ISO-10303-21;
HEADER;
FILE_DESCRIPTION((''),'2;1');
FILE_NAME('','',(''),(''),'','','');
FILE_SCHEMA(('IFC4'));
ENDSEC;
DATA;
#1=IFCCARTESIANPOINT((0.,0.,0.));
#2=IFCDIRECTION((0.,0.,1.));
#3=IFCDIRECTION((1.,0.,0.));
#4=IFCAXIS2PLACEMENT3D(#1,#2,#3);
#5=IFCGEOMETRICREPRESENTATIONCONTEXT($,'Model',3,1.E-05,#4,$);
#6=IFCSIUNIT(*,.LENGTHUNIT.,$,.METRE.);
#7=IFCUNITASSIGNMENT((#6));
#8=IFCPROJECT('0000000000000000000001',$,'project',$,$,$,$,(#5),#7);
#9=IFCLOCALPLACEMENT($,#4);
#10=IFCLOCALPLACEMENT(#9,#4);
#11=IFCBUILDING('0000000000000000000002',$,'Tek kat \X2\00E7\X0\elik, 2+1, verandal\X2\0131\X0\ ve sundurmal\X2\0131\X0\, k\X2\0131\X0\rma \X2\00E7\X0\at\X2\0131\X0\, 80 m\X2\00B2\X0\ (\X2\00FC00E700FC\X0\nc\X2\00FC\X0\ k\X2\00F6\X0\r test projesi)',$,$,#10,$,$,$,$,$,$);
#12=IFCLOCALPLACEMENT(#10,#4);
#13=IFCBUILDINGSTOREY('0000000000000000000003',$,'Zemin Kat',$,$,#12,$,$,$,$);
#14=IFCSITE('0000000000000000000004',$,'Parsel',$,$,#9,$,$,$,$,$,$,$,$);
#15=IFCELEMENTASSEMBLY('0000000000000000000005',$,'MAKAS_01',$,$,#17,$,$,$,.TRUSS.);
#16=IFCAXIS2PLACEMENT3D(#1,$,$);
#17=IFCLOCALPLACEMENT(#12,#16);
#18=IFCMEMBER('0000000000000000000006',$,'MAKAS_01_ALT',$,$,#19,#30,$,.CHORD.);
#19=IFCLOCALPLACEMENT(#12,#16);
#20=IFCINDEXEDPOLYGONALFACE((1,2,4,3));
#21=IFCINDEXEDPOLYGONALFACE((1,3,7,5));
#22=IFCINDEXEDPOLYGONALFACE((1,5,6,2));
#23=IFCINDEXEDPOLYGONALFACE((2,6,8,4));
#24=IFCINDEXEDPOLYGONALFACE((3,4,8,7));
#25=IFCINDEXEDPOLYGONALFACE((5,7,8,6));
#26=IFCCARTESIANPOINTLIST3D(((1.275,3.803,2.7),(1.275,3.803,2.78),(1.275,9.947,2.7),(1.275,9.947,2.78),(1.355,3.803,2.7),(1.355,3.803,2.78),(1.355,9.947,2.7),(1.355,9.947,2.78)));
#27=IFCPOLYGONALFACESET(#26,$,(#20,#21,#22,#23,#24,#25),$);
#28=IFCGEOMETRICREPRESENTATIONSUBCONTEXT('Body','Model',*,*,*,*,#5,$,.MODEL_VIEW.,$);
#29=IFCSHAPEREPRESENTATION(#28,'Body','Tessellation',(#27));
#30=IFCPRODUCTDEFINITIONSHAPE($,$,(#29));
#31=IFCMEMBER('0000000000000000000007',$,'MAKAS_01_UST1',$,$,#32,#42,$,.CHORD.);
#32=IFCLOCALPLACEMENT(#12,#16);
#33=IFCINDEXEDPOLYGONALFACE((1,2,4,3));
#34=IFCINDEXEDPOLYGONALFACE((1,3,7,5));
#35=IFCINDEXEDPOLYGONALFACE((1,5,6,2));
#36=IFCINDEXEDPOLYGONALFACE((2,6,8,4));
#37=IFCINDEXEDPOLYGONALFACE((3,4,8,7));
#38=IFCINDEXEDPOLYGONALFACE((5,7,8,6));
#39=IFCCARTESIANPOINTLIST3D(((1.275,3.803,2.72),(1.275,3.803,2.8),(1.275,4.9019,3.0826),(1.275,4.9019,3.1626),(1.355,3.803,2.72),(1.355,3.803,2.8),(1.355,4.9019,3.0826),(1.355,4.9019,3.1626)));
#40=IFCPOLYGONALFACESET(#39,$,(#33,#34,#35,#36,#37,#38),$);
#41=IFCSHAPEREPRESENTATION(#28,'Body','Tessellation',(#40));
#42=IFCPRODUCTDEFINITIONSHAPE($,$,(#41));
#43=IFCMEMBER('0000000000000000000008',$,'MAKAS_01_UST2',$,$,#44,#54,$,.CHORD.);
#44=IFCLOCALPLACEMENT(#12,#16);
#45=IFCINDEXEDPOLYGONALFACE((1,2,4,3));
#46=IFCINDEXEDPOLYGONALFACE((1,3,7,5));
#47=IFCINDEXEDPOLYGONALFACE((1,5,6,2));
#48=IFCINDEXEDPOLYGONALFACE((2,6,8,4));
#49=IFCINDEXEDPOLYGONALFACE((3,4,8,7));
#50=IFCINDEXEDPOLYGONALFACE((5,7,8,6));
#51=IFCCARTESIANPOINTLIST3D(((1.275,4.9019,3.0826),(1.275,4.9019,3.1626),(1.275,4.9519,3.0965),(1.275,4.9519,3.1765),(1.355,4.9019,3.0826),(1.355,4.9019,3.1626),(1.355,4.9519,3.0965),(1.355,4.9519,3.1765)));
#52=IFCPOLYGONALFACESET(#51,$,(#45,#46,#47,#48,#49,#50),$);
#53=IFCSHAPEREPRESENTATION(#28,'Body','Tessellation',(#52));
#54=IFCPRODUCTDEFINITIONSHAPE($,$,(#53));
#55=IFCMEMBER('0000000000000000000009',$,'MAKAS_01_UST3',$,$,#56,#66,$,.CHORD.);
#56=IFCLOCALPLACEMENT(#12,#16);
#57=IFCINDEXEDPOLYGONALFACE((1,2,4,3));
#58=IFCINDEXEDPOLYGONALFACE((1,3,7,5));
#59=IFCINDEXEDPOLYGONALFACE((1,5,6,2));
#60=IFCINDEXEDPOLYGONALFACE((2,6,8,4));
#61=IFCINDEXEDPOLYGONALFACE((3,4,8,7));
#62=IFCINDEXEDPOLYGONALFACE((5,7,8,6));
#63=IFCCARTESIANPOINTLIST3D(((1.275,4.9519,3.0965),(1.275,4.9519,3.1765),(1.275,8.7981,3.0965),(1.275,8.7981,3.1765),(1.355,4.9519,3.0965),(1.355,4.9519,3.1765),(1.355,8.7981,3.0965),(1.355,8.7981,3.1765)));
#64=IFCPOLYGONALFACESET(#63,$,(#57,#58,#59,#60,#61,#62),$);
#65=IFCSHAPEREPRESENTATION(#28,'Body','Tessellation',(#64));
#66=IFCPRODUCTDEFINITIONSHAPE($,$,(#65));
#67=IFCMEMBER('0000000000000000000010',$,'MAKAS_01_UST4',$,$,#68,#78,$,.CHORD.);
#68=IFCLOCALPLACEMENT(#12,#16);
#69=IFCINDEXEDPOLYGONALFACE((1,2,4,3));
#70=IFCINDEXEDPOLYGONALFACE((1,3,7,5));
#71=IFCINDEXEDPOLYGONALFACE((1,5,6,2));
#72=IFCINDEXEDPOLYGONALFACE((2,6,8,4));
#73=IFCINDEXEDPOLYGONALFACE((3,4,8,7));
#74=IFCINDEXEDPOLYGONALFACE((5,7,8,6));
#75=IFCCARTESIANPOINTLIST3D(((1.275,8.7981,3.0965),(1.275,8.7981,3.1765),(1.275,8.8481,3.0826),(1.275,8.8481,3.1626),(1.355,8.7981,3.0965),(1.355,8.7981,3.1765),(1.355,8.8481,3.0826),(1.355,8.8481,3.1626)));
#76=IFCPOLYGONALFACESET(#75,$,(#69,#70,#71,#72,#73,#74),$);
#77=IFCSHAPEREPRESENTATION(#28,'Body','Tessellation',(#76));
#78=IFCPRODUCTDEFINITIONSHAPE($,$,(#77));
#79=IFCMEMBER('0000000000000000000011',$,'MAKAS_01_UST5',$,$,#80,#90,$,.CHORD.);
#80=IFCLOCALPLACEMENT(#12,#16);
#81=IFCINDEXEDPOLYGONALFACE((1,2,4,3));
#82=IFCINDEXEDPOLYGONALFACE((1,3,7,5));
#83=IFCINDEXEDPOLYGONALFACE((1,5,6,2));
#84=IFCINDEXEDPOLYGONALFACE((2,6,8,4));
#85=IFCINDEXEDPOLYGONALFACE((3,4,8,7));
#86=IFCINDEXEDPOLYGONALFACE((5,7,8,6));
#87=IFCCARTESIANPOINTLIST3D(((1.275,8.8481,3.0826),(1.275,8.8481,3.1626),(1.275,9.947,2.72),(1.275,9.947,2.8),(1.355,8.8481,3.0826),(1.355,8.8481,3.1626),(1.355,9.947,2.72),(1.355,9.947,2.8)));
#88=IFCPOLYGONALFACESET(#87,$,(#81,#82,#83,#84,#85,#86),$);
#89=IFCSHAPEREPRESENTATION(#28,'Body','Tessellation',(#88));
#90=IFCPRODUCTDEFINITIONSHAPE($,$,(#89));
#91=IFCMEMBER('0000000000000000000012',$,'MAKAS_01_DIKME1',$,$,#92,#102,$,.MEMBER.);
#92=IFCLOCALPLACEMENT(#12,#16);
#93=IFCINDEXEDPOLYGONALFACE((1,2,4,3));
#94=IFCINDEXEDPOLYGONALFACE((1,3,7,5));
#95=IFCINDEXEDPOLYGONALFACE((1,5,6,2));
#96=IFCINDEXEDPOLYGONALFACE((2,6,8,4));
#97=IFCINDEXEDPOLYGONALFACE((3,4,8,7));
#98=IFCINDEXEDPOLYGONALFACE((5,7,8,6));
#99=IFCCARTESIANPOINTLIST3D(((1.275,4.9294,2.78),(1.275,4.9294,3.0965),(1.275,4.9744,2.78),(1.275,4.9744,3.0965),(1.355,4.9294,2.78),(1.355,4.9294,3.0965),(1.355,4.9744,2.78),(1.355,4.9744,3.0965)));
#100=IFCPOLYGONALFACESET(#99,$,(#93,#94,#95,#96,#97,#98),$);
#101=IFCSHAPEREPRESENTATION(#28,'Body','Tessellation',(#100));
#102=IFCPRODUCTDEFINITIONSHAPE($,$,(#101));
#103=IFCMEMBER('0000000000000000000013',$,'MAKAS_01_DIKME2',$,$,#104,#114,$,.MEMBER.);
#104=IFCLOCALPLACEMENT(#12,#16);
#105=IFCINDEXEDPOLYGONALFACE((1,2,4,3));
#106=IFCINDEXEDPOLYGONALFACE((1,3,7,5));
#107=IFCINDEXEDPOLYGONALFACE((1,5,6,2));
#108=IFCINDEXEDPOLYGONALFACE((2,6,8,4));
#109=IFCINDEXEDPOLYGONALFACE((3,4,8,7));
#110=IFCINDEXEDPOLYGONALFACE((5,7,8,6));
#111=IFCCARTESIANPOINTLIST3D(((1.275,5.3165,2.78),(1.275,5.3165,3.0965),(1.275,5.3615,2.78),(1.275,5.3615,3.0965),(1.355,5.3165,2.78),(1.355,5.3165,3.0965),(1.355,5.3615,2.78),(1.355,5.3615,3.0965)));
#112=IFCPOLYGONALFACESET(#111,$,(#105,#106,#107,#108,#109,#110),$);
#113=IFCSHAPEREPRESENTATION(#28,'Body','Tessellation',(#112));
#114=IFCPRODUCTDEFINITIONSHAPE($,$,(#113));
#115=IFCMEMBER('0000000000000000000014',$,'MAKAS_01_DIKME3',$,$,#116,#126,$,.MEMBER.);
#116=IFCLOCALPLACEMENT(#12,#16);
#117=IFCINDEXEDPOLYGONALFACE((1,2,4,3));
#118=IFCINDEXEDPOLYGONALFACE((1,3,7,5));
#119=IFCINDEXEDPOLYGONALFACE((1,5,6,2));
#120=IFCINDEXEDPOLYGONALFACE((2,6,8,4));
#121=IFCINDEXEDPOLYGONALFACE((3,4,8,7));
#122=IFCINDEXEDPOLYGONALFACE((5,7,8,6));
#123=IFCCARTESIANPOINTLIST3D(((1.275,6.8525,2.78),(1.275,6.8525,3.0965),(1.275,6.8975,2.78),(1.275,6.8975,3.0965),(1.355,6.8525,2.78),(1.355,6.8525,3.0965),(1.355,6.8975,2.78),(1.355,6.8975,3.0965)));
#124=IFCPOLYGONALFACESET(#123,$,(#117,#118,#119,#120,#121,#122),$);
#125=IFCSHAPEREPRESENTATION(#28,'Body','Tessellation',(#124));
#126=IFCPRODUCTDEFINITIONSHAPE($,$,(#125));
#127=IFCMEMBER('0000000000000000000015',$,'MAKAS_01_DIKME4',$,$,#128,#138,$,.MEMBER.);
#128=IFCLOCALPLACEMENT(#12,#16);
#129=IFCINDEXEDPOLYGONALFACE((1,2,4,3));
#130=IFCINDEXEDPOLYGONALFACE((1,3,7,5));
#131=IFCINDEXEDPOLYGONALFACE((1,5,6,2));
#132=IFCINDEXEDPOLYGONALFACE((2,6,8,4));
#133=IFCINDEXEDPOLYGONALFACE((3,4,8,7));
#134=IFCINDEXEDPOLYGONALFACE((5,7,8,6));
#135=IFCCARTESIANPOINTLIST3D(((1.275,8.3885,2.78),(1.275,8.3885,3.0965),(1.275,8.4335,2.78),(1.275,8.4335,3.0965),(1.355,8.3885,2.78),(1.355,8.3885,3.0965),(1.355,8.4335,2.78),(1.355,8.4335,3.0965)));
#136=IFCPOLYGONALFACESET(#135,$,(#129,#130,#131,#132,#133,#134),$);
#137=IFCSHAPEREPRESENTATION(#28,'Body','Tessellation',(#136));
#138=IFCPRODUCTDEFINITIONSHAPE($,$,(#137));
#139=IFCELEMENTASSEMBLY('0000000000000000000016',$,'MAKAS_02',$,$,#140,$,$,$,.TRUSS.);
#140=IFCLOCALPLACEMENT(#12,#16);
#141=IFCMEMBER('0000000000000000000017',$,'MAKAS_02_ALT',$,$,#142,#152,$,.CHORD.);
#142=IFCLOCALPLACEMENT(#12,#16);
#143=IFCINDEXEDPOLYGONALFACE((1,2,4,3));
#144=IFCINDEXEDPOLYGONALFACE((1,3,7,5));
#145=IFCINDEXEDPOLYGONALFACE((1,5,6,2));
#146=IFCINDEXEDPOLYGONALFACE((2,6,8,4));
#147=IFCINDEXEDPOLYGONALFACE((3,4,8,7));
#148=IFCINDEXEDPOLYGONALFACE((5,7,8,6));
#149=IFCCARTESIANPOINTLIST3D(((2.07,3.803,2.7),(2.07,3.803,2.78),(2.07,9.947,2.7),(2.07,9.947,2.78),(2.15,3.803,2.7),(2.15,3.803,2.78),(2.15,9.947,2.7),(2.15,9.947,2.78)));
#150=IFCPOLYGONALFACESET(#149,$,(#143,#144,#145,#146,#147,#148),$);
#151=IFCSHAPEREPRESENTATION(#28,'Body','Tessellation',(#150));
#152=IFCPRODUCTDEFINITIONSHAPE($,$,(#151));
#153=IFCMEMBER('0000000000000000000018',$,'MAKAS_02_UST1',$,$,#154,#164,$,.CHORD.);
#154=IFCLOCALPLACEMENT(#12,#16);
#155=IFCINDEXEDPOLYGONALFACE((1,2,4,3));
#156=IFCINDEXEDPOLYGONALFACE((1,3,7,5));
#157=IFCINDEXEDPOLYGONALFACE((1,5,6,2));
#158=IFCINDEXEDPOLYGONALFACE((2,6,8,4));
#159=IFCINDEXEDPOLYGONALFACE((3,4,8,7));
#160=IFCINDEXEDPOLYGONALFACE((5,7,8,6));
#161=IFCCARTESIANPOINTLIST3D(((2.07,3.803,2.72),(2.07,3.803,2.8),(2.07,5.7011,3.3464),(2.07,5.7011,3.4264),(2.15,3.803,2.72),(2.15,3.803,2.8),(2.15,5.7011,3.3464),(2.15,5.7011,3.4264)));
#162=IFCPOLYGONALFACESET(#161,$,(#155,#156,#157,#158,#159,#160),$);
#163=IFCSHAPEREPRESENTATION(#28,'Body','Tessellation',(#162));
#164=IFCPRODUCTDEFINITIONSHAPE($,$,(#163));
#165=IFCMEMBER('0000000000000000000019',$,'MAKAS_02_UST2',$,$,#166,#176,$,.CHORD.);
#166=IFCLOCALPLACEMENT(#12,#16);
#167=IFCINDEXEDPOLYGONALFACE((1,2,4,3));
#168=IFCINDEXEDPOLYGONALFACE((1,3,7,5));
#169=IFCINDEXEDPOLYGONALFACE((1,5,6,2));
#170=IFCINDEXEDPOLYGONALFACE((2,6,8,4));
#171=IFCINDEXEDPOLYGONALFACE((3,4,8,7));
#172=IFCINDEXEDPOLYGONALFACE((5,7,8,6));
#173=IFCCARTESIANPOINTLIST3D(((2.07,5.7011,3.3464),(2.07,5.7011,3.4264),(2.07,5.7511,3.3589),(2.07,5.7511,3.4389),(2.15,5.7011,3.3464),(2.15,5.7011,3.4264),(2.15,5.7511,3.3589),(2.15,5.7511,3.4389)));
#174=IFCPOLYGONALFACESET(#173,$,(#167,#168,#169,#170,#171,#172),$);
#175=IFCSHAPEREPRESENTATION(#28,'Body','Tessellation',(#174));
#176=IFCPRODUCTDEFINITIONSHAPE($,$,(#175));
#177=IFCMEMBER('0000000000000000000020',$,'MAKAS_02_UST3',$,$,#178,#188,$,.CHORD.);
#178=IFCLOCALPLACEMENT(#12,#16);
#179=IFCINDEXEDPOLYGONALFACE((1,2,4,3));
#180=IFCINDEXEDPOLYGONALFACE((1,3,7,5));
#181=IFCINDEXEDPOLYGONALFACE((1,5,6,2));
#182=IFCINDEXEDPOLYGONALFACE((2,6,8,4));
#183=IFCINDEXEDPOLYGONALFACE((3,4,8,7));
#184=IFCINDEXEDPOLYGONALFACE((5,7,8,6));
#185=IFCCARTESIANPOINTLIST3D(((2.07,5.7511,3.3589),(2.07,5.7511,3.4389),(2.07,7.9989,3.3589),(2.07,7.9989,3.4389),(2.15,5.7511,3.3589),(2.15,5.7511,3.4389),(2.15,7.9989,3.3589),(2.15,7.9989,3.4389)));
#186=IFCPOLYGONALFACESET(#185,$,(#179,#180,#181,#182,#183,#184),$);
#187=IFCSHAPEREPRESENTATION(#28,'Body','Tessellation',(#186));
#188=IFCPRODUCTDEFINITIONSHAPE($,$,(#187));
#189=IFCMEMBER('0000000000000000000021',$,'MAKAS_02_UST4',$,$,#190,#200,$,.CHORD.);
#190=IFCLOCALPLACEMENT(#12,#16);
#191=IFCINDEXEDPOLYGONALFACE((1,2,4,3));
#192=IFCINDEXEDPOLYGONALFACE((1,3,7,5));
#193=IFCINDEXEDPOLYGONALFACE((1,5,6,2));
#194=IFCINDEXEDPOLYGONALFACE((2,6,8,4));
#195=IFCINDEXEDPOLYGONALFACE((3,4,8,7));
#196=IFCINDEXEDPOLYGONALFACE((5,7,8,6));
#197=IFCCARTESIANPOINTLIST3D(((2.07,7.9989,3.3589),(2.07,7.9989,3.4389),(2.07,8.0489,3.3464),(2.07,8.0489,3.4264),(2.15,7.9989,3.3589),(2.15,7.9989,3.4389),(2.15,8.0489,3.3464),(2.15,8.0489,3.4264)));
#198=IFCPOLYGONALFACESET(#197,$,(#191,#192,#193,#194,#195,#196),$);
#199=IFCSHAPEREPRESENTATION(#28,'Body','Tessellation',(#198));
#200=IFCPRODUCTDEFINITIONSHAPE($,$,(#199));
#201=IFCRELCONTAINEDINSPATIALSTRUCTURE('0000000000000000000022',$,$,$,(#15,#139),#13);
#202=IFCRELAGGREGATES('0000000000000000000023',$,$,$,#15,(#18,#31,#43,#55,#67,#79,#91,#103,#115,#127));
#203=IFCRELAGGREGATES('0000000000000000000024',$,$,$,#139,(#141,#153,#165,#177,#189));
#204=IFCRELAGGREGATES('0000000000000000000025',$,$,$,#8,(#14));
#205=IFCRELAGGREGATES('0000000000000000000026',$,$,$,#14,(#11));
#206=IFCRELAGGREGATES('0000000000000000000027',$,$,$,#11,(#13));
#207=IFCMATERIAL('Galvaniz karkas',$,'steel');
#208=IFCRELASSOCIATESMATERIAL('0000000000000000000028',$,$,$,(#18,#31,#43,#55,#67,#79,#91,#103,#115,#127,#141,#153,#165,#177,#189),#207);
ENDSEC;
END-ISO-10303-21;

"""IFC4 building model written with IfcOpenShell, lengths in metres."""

from ifc_helpers import new_model, si_unit, frame, origin_with_axes, place, context, subcontext, project, spatial, line, indexed_curve, outline, extrude, material, element, aggregate, save


model = new_model("IFC4")

# Units and contexts
model_context = context("Model", 3, precision=1e-05, world=origin_with_axes())
body_context = subcontext(model_context, "Body", "Model", "MODEL_VIEW")
ifc_project = project(units=[si_unit("LENGTHUNIT", "METRE")], contexts=[model_context])

# Site, building, storey
site_placement = place(None, origin_with_axes())
site = spatial("IfcSite", under=ifc_project, at=site_placement, Name="Parsel")
building_placement = place(site_placement, origin_with_axes())
building = spatial("IfcBuilding", under=site, at=building_placement, Name="Tek kat çelik, 2+1, verandalı ve sundurmalı, kırma çatı, 80 m² (üçüncü kör test projesi)")
storey_placement = place(building_placement, origin_with_axes())
storey = spatial("IfcBuildingStorey", under=building, at=storey_placement, Name="Zemin Kat")

# Element assemblies, members
assembly_1_placement = place(storey_placement, origin_with_axes())
assembly_1 = element("IfcElementAssembly", 1, at=assembly_1_placement, inside=storey, Name="MAKAS_01", PredefinedType="TRUSS")
ifc_material_1 = material(Name="Galvaniz karkas", Category="steel")
member_1_placement = place(assembly_1_placement, origin_with_axes())
member_1 = element("IfcMember", 2, at=member_1_placement, material=ifc_material_1, Name="MAKAS_01_ALT", PredefinedType="CHORD", context=body_context, shape_type="SweptSolid", body=[
    extrude(outline(indexed_curve([(3.803, 2.7), (9.947, 2.7), (9.947, 2.78), (3.803, 2.78)], segments=[line(1, 2, 3, 4, 1)])), frame((1.275, 0.0, 0.0), z_axis=(1.0, 0.0, 0.0), x_axis=(0.0, 1.0, 0.0)), (0.0, 0.0, 1.0), 0.08),
])
member_2_placement = place(assembly_1_placement, origin_with_axes())
member_2 = element("IfcMember", 3, at=member_2_placement, material=ifc_material_1, Name="MAKAS_01_UST1", PredefinedType="CHORD", context=body_context, shape_type="SweptSolid", body=[
    extrude(outline(indexed_curve([(3.803, 2.72), (4.9019, 3.0826), (4.9019, 3.1626), (3.803, 2.8)], segments=[line(1, 2, 3, 4, 1)])), frame((1.275, 0.0, 0.0), z_axis=(1.0, 0.0, 0.0), x_axis=(0.0, 1.0, 0.0)), (0.0, 0.0, 1.0), 0.08),
])
member_3_placement = place(assembly_1_placement, origin_with_axes())
member_3 = element("IfcMember", 4, at=member_3_placement, material=ifc_material_1, Name="MAKAS_01_UST2", PredefinedType="CHORD", context=body_context, shape_type="SweptSolid", body=[
    extrude(outline(indexed_curve([(4.9019, 3.0826), (4.9519, 3.0965), (4.9519, 3.1765), (4.9019, 3.1626)], segments=[line(1, 2, 3, 4, 1)])), frame((1.275, 0.0, 0.0), z_axis=(1.0, 0.0, 0.0), x_axis=(0.0, 1.0, 0.0)), (0.0, 0.0, 1.0), 0.08),
])
member_4_placement = place(assembly_1_placement, origin_with_axes())
member_4 = element("IfcMember", 5, at=member_4_placement, material=ifc_material_1, Name="MAKAS_01_UST3", PredefinedType="CHORD", context=body_context, shape_type="SweptSolid", body=[
    extrude(outline(indexed_curve([(4.9519, 3.0965), (8.7981, 3.0965), (8.7981, 3.1765), (4.9519, 3.1765)], segments=[line(1, 2, 3, 4, 1)])), frame((1.275, 0.0, 0.0), z_axis=(1.0, 0.0, 0.0), x_axis=(0.0, 1.0, 0.0)), (0.0, 0.0, 1.0), 0.08),
])
member_5_placement = place(assembly_1_placement, origin_with_axes())
member_5 = element("IfcMember", 6, at=member_5_placement, material=ifc_material_1, Name="MAKAS_01_UST4", PredefinedType="CHORD", context=body_context, shape_type="SweptSolid", body=[
    extrude(outline(indexed_curve([(8.7981, 3.0965), (8.8481, 3.0826), (8.8481, 3.1626), (8.7981, 3.1765)], segments=[line(1, 2, 3, 4, 1)])), frame((1.275, 0.0, 0.0), z_axis=(1.0, 0.0, 0.0), x_axis=(0.0, 1.0, 0.0)), (0.0, 0.0, 1.0), 0.08),
])
member_6_placement = place(assembly_1_placement, origin_with_axes())
member_6 = element("IfcMember", 7, at=member_6_placement, material=ifc_material_1, Name="MAKAS_01_UST5", PredefinedType="CHORD", context=body_context, shape_type="SweptSolid", body=[
    extrude(outline(indexed_curve([(8.8481, 3.0826), (9.947, 2.72), (9.947, 2.8), (8.8481, 3.1626)], segments=[line(1, 2, 3, 4, 1)])), frame((1.275, 0.0, 0.0), z_axis=(1.0, 0.0, 0.0), x_axis=(0.0, 1.0, 0.0)), (0.0, 0.0, 1.0), 0.08),
])
member_7_placement = place(assembly_1_placement, origin_with_axes())
member_7 = element("IfcMember", 8, at=member_7_placement, material=ifc_material_1, Name="MAKAS_01_DIKME1", PredefinedType="MEMBER", context=body_context, shape_type="SweptSolid", body=[
    extrude(outline(indexed_curve([(4.9294, 2.78), (4.9744, 2.78), (4.9744, 3.0965), (4.9294, 3.0965)], segments=[line(1, 2, 3, 4, 1)])), frame((1.275, 0.0, 0.0), z_axis=(1.0, 0.0, 0.0), x_axis=(0.0, 1.0, 0.0)), (0.0, 0.0, 1.0), 0.08),
])
member_8_placement = place(assembly_1_placement, origin_with_axes())
member_8 = element("IfcMember", 9, at=member_8_placement, material=ifc_material_1, Name="MAKAS_01_DIKME2", PredefinedType="MEMBER", context=body_context, shape_type="SweptSolid", body=[
    extrude(outline(indexed_curve([(5.3165, 2.78), (5.3615, 2.78), (5.3615, 3.0965), (5.3165, 3.0965)], segments=[line(1, 2, 3, 4, 1)])), frame((1.275, 0.0, 0.0), z_axis=(1.0, 0.0, 0.0), x_axis=(0.0, 1.0, 0.0)), (0.0, 0.0, 1.0), 0.08),
])
member_9_placement = place(assembly_1_placement, origin_with_axes())
member_9 = element("IfcMember", 10, at=member_9_placement, material=ifc_material_1, Name="MAKAS_01_DIKME3", PredefinedType="MEMBER", context=body_context, shape_type="SweptSolid", body=[
    extrude(outline(indexed_curve([(6.8525, 2.78), (6.8975, 2.78), (6.8975, 3.0965), (6.8525, 3.0965)], segments=[line(1, 2, 3, 4, 1)])), frame((1.275, 0.0, 0.0), z_axis=(1.0, 0.0, 0.0), x_axis=(0.0, 1.0, 0.0)), (0.0, 0.0, 1.0), 0.08),
])
member_10_placement = place(assembly_1_placement, origin_with_axes())
member_10 = element("IfcMember", 11, at=member_10_placement, material=ifc_material_1, Name="MAKAS_01_DIKME4", PredefinedType="MEMBER", context=body_context, shape_type="SweptSolid", body=[
    extrude(outline(indexed_curve([(8.3885, 2.78), (8.4335, 2.78), (8.4335, 3.0965), (8.3885, 3.0965)], segments=[line(1, 2, 3, 4, 1)])), frame((1.275, 0.0, 0.0), z_axis=(1.0, 0.0, 0.0), x_axis=(0.0, 1.0, 0.0)), (0.0, 0.0, 1.0), 0.08),
])
aggregate(assembly_1, [member_1, member_2, member_3, member_4, member_5, member_6, member_7, member_8, member_9, member_10])
assembly_2_placement = place(storey_placement, origin_with_axes())
assembly_2 = element("IfcElementAssembly", 12, at=assembly_2_placement, inside=storey, Name="MAKAS_02", PredefinedType="TRUSS")
member_11_placement = place(assembly_2_placement, origin_with_axes())
member_11 = element("IfcMember", 13, at=member_11_placement, material=ifc_material_1, Name="MAKAS_02_ALT", PredefinedType="CHORD", context=body_context, shape_type="SweptSolid", body=[
    extrude(outline(indexed_curve([(3.803, 2.7), (9.947, 2.7), (9.947, 2.78), (3.803, 2.78)], segments=[line(1, 2, 3, 4, 1)])), frame((2.07, 0.0, 0.0), z_axis=(1.0, 0.0, 0.0), x_axis=(0.0, 1.0, 0.0)), (0.0, 0.0, 1.0), 0.08),
])
member_12_placement = place(assembly_2_placement, origin_with_axes())
member_12 = element("IfcMember", 14, at=member_12_placement, material=ifc_material_1, Name="MAKAS_02_UST1", PredefinedType="CHORD", context=body_context, shape_type="SweptSolid", body=[
    extrude(outline(indexed_curve([(3.803, 2.72), (5.7011, 3.3464), (5.7011, 3.4264), (3.803, 2.8)], segments=[line(1, 2, 3, 4, 1)])), frame((2.07, 0.0, 0.0), z_axis=(1.0, 0.0, 0.0), x_axis=(0.0, 1.0, 0.0)), (0.0, 0.0, 1.0), 0.08),
])
member_13_placement = place(assembly_2_placement, origin_with_axes())
member_13 = element("IfcMember", 15, at=member_13_placement, material=ifc_material_1, Name="MAKAS_02_UST2", PredefinedType="CHORD", context=body_context, shape_type="SweptSolid", body=[
    extrude(outline(indexed_curve([(5.7011, 3.3464), (5.7511, 3.3589), (5.7511, 3.4389), (5.7011, 3.4264)], segments=[line(1, 2, 3, 4, 1)])), frame((2.07, 0.0, 0.0), z_axis=(1.0, 0.0, 0.0), x_axis=(0.0, 1.0, 0.0)), (0.0, 0.0, 1.0), 0.08),
])
member_14_placement = place(assembly_2_placement, origin_with_axes())
member_14 = element("IfcMember", 16, at=member_14_placement, material=ifc_material_1, Name="MAKAS_02_UST3", PredefinedType="CHORD", context=body_context, shape_type="SweptSolid", body=[
    extrude(outline(indexed_curve([(5.7511, 3.3589), (7.9989, 3.3589), (7.9989, 3.4389), (5.7511, 3.4389)], segments=[line(1, 2, 3, 4, 1)])), frame((2.07, 0.0, 0.0), z_axis=(1.0, 0.0, 0.0), x_axis=(0.0, 1.0, 0.0)), (0.0, 0.0, 1.0), 0.08),
])
member_15_placement = place(assembly_2_placement, origin_with_axes())
member_15 = element("IfcMember", 17, at=member_15_placement, material=ifc_material_1, Name="MAKAS_02_UST4", PredefinedType="CHORD", context=body_context, shape_type="SweptSolid", body=[
    extrude(outline(indexed_curve([(7.9989, 3.3589), (8.0489, 3.3464), (8.0489, 3.4264), (7.9989, 3.4389)], segments=[line(1, 2, 3, 4, 1)])), frame((2.07, 0.0, 0.0), z_axis=(1.0, 0.0, 0.0), x_axis=(0.0, 1.0, 0.0)), (0.0, 0.0, 1.0), 0.08),
])
aggregate(assembly_2, [member_11, member_12, member_13, member_14, member_15])

save(model, "model.ifc")
